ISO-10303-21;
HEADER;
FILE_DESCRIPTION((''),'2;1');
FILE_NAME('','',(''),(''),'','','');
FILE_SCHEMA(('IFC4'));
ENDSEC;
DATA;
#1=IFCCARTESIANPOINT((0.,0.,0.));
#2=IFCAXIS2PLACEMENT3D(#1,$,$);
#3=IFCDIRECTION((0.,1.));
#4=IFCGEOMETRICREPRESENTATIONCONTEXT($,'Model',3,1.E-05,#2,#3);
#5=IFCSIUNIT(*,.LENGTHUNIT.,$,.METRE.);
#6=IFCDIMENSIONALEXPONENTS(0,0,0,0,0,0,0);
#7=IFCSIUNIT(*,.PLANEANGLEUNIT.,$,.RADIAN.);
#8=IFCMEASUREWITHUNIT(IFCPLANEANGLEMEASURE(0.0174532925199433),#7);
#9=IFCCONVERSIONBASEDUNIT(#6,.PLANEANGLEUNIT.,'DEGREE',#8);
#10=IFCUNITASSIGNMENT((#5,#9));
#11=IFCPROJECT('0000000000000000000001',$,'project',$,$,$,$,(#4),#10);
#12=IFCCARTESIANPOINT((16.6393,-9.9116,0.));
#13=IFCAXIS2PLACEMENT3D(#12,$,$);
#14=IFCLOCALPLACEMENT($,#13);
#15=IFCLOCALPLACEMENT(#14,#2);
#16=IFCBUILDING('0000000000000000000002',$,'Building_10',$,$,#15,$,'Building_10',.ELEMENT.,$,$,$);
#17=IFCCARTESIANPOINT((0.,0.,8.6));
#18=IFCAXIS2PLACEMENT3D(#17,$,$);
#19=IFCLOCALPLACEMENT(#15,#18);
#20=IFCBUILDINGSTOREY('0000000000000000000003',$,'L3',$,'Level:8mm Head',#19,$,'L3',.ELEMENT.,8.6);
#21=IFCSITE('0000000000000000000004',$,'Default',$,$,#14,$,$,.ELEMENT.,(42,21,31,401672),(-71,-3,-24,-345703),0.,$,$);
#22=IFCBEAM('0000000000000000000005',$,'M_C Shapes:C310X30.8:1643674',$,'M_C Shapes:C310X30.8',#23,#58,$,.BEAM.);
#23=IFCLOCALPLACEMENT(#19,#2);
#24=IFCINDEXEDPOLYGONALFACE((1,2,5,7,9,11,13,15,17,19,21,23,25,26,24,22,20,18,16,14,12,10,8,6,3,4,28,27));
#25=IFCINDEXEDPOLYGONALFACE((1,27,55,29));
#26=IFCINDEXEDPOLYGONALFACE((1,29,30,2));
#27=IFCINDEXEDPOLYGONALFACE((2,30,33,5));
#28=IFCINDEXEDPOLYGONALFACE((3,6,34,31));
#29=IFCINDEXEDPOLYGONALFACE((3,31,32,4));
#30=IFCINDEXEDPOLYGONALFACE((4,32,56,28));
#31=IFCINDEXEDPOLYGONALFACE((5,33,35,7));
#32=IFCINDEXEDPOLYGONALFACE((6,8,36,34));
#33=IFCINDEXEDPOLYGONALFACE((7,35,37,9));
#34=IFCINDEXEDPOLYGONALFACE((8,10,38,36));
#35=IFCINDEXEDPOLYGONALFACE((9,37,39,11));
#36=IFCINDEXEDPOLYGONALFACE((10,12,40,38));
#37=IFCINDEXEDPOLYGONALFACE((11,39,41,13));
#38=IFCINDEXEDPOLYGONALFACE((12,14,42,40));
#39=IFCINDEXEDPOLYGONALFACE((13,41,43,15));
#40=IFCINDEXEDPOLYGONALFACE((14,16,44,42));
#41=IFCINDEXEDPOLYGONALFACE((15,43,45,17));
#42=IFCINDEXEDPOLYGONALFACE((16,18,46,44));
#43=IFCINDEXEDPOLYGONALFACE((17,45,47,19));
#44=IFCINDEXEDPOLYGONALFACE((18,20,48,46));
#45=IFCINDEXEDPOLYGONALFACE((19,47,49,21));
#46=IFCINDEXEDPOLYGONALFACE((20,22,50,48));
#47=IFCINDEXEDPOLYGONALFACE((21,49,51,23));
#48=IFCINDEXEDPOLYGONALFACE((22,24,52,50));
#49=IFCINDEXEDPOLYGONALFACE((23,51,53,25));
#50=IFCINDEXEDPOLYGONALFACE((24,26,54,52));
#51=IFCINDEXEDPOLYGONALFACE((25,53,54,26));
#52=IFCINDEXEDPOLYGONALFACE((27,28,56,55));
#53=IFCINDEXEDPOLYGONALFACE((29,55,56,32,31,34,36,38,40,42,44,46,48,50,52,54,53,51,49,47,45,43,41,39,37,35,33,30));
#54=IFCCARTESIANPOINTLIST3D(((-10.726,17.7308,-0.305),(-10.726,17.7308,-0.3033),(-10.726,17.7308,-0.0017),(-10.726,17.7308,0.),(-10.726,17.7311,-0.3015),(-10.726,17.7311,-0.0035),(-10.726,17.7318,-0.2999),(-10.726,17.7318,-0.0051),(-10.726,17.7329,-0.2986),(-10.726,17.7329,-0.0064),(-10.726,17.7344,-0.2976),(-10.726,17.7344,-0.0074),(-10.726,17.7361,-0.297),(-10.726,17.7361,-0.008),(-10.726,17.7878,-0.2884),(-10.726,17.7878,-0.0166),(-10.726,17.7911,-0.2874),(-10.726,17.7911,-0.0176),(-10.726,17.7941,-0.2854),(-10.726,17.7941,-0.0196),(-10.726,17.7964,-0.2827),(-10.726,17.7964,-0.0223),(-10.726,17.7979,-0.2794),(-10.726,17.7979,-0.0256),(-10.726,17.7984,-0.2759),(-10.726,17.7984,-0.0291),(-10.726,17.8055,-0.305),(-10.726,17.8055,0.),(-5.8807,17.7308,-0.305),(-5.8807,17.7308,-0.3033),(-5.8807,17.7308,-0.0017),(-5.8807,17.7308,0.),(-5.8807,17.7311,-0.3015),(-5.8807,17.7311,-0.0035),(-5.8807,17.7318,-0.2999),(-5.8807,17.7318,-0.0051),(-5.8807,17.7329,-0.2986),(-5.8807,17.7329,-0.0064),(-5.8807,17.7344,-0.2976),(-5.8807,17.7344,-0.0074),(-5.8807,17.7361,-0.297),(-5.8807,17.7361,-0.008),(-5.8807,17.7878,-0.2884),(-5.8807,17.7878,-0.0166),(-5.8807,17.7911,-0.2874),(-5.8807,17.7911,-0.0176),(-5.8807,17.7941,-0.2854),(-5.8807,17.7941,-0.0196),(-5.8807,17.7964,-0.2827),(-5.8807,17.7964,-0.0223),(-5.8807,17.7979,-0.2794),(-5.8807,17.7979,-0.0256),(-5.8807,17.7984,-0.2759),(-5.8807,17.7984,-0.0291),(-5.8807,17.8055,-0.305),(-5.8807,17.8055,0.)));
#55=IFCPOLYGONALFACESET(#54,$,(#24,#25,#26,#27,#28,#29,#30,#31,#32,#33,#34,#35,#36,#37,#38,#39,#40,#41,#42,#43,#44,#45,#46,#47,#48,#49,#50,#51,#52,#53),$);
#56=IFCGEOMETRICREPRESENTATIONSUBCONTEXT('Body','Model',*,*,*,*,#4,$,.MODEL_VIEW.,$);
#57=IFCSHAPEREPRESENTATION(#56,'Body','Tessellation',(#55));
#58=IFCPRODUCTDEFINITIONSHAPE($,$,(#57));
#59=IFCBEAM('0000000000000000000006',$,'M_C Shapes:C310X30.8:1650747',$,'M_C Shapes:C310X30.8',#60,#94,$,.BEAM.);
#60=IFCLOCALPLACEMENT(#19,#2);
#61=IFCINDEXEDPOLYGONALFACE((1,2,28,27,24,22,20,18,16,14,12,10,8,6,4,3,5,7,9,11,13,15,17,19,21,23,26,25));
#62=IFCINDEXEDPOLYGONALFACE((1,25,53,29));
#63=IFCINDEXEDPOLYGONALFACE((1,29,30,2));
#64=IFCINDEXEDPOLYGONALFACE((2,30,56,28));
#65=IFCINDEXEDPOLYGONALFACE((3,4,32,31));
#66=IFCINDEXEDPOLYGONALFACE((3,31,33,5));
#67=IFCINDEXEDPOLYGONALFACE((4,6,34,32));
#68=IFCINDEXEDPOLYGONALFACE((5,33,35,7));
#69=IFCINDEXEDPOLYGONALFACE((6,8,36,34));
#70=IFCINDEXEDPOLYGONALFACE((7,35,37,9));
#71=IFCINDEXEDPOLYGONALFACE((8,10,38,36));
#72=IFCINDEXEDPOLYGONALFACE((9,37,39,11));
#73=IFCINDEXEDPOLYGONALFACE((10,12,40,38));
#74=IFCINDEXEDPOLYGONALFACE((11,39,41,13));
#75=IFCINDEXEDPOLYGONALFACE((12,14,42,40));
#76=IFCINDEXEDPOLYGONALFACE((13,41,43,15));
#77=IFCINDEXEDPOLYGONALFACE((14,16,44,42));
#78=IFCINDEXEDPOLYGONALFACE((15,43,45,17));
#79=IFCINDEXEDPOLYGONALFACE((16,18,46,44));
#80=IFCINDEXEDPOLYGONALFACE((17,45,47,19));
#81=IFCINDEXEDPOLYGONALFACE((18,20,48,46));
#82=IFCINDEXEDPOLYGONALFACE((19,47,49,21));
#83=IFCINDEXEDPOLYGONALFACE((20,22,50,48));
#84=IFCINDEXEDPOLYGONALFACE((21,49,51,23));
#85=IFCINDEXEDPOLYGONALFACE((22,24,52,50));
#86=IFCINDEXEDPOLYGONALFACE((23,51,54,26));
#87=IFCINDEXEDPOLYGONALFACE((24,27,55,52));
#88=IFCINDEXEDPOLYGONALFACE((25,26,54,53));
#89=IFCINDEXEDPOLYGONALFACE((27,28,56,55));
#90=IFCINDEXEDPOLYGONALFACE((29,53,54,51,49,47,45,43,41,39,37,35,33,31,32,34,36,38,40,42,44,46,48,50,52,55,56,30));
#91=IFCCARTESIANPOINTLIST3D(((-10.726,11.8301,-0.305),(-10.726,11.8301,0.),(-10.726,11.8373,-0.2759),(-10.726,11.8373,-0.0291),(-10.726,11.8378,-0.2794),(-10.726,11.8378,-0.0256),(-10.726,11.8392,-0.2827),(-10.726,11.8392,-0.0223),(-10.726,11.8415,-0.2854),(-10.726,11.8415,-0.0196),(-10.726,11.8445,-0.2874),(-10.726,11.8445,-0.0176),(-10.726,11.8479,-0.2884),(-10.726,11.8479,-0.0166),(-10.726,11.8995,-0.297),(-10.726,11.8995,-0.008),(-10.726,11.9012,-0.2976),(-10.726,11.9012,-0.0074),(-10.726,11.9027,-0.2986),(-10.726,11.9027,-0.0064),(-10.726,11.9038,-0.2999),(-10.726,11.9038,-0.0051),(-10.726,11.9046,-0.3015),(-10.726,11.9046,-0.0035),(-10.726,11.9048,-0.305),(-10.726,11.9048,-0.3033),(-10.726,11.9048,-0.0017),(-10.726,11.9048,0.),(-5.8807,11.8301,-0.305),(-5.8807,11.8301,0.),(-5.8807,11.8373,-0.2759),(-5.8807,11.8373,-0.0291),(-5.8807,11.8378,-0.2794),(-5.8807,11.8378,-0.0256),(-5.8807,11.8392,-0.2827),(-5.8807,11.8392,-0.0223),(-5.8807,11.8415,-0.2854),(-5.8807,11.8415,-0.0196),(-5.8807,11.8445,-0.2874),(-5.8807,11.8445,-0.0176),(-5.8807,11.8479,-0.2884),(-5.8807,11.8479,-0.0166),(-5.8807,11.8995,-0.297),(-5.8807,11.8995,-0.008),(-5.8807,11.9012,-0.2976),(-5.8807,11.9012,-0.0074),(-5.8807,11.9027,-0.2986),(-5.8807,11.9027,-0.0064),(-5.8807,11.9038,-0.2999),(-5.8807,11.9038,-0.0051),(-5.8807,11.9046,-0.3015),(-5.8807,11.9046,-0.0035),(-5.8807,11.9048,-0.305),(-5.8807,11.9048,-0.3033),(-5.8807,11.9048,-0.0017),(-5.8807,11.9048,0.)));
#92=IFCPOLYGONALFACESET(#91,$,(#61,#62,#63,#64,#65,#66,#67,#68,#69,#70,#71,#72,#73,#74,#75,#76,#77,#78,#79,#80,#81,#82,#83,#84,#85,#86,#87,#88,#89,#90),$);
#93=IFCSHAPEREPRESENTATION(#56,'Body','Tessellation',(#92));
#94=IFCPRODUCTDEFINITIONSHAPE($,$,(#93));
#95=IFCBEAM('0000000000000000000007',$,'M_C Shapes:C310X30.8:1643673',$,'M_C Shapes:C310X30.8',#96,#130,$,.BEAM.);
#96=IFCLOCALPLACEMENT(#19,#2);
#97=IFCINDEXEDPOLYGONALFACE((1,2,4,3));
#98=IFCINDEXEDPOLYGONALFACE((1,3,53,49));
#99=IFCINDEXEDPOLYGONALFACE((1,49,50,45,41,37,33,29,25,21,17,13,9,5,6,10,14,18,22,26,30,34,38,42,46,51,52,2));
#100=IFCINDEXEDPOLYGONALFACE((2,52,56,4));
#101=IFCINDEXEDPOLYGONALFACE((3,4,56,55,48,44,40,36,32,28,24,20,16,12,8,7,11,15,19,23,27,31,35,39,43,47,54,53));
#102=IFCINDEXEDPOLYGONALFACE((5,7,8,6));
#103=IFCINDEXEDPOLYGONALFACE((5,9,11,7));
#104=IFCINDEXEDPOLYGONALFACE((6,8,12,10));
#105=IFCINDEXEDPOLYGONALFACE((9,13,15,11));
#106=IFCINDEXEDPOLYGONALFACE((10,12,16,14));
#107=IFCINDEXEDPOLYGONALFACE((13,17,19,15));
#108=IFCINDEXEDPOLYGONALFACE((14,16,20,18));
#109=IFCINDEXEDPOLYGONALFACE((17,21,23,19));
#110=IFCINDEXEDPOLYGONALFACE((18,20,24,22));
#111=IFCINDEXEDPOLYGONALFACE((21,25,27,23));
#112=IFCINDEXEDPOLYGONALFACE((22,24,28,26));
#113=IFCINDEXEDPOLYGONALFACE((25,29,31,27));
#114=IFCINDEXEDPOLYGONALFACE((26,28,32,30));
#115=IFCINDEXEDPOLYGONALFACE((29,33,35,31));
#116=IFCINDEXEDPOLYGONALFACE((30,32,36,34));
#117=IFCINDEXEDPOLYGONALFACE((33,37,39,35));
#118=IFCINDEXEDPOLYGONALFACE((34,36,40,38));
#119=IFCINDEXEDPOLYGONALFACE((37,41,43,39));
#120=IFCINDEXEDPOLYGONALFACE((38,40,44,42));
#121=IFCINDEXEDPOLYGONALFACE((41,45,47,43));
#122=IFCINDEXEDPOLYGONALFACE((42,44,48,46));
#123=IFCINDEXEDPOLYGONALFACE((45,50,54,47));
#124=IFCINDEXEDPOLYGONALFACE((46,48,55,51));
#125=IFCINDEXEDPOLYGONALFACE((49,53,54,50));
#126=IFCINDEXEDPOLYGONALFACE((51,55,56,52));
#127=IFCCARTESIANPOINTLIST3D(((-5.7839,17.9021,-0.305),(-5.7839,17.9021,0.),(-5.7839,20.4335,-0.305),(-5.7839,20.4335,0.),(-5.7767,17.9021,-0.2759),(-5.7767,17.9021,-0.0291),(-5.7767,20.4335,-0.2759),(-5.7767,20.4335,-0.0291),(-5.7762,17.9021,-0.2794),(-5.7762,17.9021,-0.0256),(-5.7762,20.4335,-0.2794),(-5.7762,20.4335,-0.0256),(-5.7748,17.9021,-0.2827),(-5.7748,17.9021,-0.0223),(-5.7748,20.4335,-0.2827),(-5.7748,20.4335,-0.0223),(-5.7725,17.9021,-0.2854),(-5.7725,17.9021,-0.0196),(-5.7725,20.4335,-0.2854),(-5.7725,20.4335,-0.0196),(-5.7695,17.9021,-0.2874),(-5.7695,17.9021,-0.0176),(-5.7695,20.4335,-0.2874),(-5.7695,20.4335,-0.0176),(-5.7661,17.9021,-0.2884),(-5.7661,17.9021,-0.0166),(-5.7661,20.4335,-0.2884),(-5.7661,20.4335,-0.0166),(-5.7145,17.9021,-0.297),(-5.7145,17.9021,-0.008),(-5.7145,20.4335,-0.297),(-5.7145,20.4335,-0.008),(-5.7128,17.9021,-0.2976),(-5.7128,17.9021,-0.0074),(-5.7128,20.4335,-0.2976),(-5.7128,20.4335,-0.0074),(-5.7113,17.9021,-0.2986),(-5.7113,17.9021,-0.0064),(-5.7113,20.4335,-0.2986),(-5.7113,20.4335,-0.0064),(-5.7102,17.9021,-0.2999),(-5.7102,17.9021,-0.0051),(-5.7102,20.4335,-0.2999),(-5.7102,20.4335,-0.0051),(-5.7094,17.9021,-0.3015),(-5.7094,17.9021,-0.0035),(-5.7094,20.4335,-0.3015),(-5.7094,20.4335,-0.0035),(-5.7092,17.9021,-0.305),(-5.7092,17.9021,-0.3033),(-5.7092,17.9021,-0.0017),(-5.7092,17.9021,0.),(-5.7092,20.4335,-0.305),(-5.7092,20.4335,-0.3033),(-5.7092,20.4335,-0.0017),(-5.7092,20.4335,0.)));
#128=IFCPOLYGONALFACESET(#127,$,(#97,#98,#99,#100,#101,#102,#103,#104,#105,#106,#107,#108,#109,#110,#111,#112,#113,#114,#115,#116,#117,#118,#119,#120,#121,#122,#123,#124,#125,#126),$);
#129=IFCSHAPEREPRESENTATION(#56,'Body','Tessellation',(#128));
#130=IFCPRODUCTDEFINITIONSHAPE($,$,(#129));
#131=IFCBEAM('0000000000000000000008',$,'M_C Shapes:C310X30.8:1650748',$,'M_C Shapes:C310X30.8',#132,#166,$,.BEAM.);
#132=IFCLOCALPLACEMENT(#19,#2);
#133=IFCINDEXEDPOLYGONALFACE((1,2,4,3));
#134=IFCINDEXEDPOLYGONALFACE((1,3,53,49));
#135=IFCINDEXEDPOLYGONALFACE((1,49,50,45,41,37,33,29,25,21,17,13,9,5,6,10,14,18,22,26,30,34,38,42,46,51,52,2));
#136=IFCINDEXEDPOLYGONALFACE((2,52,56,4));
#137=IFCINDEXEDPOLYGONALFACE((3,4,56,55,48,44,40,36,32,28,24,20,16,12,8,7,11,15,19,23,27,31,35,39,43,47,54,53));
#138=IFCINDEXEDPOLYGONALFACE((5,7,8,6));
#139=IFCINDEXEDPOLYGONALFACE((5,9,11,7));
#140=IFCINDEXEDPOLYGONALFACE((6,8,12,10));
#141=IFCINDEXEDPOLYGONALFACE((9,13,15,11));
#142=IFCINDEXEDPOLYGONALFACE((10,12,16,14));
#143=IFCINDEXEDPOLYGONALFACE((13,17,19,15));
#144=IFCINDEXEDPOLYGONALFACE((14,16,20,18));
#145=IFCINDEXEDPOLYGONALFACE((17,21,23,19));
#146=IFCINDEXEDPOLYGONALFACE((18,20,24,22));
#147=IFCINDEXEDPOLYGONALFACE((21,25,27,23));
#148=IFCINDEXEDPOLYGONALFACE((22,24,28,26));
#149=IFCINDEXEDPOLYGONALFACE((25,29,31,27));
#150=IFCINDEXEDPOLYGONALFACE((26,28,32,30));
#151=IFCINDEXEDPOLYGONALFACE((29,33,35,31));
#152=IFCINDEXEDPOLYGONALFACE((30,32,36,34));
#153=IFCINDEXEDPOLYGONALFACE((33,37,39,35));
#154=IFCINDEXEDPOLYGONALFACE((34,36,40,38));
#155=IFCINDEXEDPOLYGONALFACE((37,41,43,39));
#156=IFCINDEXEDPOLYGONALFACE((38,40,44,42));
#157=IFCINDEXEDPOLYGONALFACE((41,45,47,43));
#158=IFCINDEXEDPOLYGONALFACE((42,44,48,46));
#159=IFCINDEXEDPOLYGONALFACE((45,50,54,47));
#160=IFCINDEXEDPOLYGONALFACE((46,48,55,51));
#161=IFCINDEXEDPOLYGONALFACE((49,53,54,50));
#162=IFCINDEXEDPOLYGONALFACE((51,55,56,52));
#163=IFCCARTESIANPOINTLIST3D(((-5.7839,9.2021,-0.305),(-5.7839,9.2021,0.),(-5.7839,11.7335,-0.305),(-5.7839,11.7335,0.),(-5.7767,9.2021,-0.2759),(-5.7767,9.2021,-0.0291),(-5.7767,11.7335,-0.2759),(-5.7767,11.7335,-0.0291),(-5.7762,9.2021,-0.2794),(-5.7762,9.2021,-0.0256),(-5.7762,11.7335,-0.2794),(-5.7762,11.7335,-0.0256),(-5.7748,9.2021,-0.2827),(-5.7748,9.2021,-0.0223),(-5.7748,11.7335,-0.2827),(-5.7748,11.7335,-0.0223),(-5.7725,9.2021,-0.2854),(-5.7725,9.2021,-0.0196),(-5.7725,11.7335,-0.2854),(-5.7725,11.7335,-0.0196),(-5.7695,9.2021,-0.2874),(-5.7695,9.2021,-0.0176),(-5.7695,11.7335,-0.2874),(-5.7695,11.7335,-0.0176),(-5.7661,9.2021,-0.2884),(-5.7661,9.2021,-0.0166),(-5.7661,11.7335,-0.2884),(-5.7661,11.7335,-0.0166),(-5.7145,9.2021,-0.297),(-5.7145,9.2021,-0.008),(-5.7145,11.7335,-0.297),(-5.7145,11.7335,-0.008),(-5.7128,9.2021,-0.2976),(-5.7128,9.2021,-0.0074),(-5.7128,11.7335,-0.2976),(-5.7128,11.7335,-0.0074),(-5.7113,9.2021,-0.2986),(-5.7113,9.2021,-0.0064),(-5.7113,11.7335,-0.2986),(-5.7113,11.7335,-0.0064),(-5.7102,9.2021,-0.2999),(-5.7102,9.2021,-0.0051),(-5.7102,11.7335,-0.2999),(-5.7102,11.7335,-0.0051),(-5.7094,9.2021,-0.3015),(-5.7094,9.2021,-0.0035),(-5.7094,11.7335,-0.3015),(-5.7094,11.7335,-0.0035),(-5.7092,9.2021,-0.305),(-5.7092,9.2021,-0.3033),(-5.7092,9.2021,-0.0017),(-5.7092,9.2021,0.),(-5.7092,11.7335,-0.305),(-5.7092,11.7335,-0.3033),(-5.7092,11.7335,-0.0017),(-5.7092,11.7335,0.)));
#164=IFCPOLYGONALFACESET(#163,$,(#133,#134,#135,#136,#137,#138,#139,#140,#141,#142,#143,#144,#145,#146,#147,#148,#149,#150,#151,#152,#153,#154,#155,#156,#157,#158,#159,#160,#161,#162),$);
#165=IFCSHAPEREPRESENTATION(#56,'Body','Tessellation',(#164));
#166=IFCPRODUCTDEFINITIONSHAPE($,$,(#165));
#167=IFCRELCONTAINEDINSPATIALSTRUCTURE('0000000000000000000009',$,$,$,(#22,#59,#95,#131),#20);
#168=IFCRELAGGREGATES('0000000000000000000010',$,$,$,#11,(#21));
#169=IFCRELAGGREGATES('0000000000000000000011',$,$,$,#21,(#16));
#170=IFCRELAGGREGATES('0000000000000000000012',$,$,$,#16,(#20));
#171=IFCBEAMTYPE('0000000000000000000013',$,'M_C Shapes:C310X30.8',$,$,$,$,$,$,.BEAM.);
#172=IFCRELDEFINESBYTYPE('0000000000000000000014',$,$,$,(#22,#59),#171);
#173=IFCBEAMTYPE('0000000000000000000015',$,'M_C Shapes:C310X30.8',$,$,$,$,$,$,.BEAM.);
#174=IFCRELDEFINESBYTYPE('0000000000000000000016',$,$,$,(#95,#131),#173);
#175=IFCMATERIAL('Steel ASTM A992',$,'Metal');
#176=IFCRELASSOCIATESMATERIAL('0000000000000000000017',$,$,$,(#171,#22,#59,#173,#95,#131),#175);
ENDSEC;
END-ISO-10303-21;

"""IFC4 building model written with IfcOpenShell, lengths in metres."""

from ifc_helpers import new_model, entity, si_unit, converted_unit, direction, frame, origin, place, context, subcontext, project, spatial, line, arc, indexed_curve, outline, extrude, source, transform, mapped, material, type_object, type_shapes, element, save


model = new_model("IFC4")

# Units and contexts
model_context = context("Model", 3, precision=1e-05, world=origin(), true_north=direction((0.0, 1.0)))
body_context = subcontext(model_context, "Body", "Model", "MODEL_VIEW")
ifc_project = project(units=[si_unit("LENGTHUNIT", "METRE"), converted_unit("PLANEANGLEUNIT", "DEGREE", entity("IfcPlaneAngleMeasure", 0.0174532925199433), si_unit("PLANEANGLEUNIT", "RADIAN"), dimensions=[0, 0, 0, 0, 0, 0, 0])], contexts=[model_context])

# Site, building, storey
site_placement = place(None, frame((16.6393, -9.9116, 0.0)))
site = spatial("IfcSite", under=ifc_project, at=site_placement, Name="Default", CompositionType="ELEMENT", RefLatitude=(42, 21, 31, 401672), RefLongitude=(-71, -3, -24, -345703), RefElevation=0.0)
building_placement = place(site_placement, origin())
building = spatial("IfcBuilding", under=site, at=building_placement, Name="Building_10", LongName="Building_10", CompositionType="ELEMENT")
storey_placement = place(building_placement, frame((0.0, 0.0, 8.6)))
storey = spatial("IfcBuildingStorey", under=building, at=storey_placement, Name="L3", ObjectType="Level:8mm Head", LongName="L3", CompositionType="ELEMENT", Elevation=8.6)

# Shared definitions
ifc_material_1 = material(Name="Steel ASTM A992", Category="Metal")

# Beams
beam_type_1 = type_object("IfcBeamType", Name="M_C Shapes:C310X30.8", PredefinedType="BEAM", material=ifc_material_1)
shared_shape_1 = source(origin(), body_context, "Body", "SweptSolid", [
    extrude(outline(indexed_curve([(-0.0406, -0.1525), (0.0341, -0.1525), (0.0341, -0.1508), (0.0326, -0.1467), (0.0288, -0.1445), (-0.0228, -0.1359), (-0.0305, -0.1316), (-0.0335, -0.1234), (-0.0335, 0.1234), (-0.0305, 0.1316), (-0.0228, 0.1359), (0.0288, 0.1445), (0.0326, 0.1467), (0.0341, 0.1508), (0.0341, 0.1525), (-0.0406, 0.1525)], segments=[line(1, 2, 3), arc(3, 4, 5), line(5, 6), arc(6, 7, 8), line(8, 9), arc(9, 10, 11), line(11, 12), arc(12, 13, 14), line(14, 15, 16, 1)], self_intersect=False)), frame((-2.4226, -0.0229, 0.0), z_axis=(1.0, 0.0, 0.0), x_axis=(0.0, -1.0, 0.0)), (0.0, 0.0, 1.0), 4.8453),
])
type_shapes(beam_type_1, [shared_shape_1])
beam_1_placement = place(storey_placement, frame((-8.3033, 17.7878, -0.1525)))
element("IfcBeam", 1, at=beam_1_placement, inside=storey, type_object=beam_type_1, material=ifc_material_1, Name="M_C Shapes:C310X30.8:1643674", ObjectType="M_C Shapes:C310X30.8", PredefinedType="BEAM", context=body_context, shape_type="MappedRepresentation", body=[
    mapped(shared_shape_1, transform((0.0, 0.0, 0.0), scale=1.0)),
])
beam_2_placement = place(storey_placement, frame((-8.3033, 11.8478, -0.1525), z_axis=(0.0, 0.0, 1.0), x_axis=(-1.0, 0.0, 0.0)))
element("IfcBeam", 2, at=beam_2_placement, inside=storey, type_object=beam_type_1, material=ifc_material_1, Name="M_C Shapes:C310X30.8:1650747", ObjectType="M_C Shapes:C310X30.8", PredefinedType="BEAM", context=body_context, shape_type="MappedRepresentation", body=[
    mapped(shared_shape_1, transform((0.0, 0.0, 0.0), scale=1.0)),
])
beam_type_2 = type_object("IfcBeamType", Name="M_C Shapes:C310X30.8", PredefinedType="BEAM", material=ifc_material_1)
shared_shape_2 = source(origin(), body_context, "Body", "SweptSolid", [
    extrude(outline(indexed_curve([(-0.0406, -0.1525), (0.0341, -0.1525), (0.0341, -0.1508), (0.0326, -0.1467), (0.0288, -0.1445), (-0.0228, -0.1359), (-0.0305, -0.1316), (-0.0335, -0.1234), (-0.0335, 0.1234), (-0.0305, 0.1316), (-0.0228, 0.1359), (0.0288, 0.1445), (0.0326, 0.1467), (0.0341, 0.1508), (0.0341, 0.1525), (-0.0406, 0.1525)], segments=[line(1, 2, 3), arc(3, 4, 5), line(5, 6), arc(6, 7, 8), line(8, 9), arc(9, 10, 11), line(11, 12), arc(12, 13, 14), line(14, 15, 16, 1)], self_intersect=False)), frame((-1.2657, -0.0229, 0.0), z_axis=(1.0, 0.0, 0.0), x_axis=(0.0, -1.0, 0.0)), (0.0, 0.0, 1.0), 2.5314),
])
type_shapes(beam_type_2, [shared_shape_2])
for number, where, z_axis, x_axis, name in (
    (3, (-5.7662, 19.1678, -0.1525), (0.0, 0.0, 1.0), (0.0, 1.0, 0.0), "M_C Shapes:C310X30.8:1643673"),
    (4, (-5.7662, 10.4678, -0.1525), (0.0, 0.0, 1.0), (0.0, 1.0, 0.0), "M_C Shapes:C310X30.8:1650748"),
):
    element("IfcBeam", number, at=place(storey_placement, frame(where, z_axis=z_axis, x_axis=x_axis)), inside=storey, type_object=beam_type_2, material=ifc_material_1, Name=name, ObjectType="M_C Shapes:C310X30.8", PredefinedType="BEAM", context=body_context, shape_type="MappedRepresentation", body=[
        mapped(shared_shape_2, transform((0.0, 0.0, 0.0), scale=1.0)),
    ])

save(model, "model.ifc")
